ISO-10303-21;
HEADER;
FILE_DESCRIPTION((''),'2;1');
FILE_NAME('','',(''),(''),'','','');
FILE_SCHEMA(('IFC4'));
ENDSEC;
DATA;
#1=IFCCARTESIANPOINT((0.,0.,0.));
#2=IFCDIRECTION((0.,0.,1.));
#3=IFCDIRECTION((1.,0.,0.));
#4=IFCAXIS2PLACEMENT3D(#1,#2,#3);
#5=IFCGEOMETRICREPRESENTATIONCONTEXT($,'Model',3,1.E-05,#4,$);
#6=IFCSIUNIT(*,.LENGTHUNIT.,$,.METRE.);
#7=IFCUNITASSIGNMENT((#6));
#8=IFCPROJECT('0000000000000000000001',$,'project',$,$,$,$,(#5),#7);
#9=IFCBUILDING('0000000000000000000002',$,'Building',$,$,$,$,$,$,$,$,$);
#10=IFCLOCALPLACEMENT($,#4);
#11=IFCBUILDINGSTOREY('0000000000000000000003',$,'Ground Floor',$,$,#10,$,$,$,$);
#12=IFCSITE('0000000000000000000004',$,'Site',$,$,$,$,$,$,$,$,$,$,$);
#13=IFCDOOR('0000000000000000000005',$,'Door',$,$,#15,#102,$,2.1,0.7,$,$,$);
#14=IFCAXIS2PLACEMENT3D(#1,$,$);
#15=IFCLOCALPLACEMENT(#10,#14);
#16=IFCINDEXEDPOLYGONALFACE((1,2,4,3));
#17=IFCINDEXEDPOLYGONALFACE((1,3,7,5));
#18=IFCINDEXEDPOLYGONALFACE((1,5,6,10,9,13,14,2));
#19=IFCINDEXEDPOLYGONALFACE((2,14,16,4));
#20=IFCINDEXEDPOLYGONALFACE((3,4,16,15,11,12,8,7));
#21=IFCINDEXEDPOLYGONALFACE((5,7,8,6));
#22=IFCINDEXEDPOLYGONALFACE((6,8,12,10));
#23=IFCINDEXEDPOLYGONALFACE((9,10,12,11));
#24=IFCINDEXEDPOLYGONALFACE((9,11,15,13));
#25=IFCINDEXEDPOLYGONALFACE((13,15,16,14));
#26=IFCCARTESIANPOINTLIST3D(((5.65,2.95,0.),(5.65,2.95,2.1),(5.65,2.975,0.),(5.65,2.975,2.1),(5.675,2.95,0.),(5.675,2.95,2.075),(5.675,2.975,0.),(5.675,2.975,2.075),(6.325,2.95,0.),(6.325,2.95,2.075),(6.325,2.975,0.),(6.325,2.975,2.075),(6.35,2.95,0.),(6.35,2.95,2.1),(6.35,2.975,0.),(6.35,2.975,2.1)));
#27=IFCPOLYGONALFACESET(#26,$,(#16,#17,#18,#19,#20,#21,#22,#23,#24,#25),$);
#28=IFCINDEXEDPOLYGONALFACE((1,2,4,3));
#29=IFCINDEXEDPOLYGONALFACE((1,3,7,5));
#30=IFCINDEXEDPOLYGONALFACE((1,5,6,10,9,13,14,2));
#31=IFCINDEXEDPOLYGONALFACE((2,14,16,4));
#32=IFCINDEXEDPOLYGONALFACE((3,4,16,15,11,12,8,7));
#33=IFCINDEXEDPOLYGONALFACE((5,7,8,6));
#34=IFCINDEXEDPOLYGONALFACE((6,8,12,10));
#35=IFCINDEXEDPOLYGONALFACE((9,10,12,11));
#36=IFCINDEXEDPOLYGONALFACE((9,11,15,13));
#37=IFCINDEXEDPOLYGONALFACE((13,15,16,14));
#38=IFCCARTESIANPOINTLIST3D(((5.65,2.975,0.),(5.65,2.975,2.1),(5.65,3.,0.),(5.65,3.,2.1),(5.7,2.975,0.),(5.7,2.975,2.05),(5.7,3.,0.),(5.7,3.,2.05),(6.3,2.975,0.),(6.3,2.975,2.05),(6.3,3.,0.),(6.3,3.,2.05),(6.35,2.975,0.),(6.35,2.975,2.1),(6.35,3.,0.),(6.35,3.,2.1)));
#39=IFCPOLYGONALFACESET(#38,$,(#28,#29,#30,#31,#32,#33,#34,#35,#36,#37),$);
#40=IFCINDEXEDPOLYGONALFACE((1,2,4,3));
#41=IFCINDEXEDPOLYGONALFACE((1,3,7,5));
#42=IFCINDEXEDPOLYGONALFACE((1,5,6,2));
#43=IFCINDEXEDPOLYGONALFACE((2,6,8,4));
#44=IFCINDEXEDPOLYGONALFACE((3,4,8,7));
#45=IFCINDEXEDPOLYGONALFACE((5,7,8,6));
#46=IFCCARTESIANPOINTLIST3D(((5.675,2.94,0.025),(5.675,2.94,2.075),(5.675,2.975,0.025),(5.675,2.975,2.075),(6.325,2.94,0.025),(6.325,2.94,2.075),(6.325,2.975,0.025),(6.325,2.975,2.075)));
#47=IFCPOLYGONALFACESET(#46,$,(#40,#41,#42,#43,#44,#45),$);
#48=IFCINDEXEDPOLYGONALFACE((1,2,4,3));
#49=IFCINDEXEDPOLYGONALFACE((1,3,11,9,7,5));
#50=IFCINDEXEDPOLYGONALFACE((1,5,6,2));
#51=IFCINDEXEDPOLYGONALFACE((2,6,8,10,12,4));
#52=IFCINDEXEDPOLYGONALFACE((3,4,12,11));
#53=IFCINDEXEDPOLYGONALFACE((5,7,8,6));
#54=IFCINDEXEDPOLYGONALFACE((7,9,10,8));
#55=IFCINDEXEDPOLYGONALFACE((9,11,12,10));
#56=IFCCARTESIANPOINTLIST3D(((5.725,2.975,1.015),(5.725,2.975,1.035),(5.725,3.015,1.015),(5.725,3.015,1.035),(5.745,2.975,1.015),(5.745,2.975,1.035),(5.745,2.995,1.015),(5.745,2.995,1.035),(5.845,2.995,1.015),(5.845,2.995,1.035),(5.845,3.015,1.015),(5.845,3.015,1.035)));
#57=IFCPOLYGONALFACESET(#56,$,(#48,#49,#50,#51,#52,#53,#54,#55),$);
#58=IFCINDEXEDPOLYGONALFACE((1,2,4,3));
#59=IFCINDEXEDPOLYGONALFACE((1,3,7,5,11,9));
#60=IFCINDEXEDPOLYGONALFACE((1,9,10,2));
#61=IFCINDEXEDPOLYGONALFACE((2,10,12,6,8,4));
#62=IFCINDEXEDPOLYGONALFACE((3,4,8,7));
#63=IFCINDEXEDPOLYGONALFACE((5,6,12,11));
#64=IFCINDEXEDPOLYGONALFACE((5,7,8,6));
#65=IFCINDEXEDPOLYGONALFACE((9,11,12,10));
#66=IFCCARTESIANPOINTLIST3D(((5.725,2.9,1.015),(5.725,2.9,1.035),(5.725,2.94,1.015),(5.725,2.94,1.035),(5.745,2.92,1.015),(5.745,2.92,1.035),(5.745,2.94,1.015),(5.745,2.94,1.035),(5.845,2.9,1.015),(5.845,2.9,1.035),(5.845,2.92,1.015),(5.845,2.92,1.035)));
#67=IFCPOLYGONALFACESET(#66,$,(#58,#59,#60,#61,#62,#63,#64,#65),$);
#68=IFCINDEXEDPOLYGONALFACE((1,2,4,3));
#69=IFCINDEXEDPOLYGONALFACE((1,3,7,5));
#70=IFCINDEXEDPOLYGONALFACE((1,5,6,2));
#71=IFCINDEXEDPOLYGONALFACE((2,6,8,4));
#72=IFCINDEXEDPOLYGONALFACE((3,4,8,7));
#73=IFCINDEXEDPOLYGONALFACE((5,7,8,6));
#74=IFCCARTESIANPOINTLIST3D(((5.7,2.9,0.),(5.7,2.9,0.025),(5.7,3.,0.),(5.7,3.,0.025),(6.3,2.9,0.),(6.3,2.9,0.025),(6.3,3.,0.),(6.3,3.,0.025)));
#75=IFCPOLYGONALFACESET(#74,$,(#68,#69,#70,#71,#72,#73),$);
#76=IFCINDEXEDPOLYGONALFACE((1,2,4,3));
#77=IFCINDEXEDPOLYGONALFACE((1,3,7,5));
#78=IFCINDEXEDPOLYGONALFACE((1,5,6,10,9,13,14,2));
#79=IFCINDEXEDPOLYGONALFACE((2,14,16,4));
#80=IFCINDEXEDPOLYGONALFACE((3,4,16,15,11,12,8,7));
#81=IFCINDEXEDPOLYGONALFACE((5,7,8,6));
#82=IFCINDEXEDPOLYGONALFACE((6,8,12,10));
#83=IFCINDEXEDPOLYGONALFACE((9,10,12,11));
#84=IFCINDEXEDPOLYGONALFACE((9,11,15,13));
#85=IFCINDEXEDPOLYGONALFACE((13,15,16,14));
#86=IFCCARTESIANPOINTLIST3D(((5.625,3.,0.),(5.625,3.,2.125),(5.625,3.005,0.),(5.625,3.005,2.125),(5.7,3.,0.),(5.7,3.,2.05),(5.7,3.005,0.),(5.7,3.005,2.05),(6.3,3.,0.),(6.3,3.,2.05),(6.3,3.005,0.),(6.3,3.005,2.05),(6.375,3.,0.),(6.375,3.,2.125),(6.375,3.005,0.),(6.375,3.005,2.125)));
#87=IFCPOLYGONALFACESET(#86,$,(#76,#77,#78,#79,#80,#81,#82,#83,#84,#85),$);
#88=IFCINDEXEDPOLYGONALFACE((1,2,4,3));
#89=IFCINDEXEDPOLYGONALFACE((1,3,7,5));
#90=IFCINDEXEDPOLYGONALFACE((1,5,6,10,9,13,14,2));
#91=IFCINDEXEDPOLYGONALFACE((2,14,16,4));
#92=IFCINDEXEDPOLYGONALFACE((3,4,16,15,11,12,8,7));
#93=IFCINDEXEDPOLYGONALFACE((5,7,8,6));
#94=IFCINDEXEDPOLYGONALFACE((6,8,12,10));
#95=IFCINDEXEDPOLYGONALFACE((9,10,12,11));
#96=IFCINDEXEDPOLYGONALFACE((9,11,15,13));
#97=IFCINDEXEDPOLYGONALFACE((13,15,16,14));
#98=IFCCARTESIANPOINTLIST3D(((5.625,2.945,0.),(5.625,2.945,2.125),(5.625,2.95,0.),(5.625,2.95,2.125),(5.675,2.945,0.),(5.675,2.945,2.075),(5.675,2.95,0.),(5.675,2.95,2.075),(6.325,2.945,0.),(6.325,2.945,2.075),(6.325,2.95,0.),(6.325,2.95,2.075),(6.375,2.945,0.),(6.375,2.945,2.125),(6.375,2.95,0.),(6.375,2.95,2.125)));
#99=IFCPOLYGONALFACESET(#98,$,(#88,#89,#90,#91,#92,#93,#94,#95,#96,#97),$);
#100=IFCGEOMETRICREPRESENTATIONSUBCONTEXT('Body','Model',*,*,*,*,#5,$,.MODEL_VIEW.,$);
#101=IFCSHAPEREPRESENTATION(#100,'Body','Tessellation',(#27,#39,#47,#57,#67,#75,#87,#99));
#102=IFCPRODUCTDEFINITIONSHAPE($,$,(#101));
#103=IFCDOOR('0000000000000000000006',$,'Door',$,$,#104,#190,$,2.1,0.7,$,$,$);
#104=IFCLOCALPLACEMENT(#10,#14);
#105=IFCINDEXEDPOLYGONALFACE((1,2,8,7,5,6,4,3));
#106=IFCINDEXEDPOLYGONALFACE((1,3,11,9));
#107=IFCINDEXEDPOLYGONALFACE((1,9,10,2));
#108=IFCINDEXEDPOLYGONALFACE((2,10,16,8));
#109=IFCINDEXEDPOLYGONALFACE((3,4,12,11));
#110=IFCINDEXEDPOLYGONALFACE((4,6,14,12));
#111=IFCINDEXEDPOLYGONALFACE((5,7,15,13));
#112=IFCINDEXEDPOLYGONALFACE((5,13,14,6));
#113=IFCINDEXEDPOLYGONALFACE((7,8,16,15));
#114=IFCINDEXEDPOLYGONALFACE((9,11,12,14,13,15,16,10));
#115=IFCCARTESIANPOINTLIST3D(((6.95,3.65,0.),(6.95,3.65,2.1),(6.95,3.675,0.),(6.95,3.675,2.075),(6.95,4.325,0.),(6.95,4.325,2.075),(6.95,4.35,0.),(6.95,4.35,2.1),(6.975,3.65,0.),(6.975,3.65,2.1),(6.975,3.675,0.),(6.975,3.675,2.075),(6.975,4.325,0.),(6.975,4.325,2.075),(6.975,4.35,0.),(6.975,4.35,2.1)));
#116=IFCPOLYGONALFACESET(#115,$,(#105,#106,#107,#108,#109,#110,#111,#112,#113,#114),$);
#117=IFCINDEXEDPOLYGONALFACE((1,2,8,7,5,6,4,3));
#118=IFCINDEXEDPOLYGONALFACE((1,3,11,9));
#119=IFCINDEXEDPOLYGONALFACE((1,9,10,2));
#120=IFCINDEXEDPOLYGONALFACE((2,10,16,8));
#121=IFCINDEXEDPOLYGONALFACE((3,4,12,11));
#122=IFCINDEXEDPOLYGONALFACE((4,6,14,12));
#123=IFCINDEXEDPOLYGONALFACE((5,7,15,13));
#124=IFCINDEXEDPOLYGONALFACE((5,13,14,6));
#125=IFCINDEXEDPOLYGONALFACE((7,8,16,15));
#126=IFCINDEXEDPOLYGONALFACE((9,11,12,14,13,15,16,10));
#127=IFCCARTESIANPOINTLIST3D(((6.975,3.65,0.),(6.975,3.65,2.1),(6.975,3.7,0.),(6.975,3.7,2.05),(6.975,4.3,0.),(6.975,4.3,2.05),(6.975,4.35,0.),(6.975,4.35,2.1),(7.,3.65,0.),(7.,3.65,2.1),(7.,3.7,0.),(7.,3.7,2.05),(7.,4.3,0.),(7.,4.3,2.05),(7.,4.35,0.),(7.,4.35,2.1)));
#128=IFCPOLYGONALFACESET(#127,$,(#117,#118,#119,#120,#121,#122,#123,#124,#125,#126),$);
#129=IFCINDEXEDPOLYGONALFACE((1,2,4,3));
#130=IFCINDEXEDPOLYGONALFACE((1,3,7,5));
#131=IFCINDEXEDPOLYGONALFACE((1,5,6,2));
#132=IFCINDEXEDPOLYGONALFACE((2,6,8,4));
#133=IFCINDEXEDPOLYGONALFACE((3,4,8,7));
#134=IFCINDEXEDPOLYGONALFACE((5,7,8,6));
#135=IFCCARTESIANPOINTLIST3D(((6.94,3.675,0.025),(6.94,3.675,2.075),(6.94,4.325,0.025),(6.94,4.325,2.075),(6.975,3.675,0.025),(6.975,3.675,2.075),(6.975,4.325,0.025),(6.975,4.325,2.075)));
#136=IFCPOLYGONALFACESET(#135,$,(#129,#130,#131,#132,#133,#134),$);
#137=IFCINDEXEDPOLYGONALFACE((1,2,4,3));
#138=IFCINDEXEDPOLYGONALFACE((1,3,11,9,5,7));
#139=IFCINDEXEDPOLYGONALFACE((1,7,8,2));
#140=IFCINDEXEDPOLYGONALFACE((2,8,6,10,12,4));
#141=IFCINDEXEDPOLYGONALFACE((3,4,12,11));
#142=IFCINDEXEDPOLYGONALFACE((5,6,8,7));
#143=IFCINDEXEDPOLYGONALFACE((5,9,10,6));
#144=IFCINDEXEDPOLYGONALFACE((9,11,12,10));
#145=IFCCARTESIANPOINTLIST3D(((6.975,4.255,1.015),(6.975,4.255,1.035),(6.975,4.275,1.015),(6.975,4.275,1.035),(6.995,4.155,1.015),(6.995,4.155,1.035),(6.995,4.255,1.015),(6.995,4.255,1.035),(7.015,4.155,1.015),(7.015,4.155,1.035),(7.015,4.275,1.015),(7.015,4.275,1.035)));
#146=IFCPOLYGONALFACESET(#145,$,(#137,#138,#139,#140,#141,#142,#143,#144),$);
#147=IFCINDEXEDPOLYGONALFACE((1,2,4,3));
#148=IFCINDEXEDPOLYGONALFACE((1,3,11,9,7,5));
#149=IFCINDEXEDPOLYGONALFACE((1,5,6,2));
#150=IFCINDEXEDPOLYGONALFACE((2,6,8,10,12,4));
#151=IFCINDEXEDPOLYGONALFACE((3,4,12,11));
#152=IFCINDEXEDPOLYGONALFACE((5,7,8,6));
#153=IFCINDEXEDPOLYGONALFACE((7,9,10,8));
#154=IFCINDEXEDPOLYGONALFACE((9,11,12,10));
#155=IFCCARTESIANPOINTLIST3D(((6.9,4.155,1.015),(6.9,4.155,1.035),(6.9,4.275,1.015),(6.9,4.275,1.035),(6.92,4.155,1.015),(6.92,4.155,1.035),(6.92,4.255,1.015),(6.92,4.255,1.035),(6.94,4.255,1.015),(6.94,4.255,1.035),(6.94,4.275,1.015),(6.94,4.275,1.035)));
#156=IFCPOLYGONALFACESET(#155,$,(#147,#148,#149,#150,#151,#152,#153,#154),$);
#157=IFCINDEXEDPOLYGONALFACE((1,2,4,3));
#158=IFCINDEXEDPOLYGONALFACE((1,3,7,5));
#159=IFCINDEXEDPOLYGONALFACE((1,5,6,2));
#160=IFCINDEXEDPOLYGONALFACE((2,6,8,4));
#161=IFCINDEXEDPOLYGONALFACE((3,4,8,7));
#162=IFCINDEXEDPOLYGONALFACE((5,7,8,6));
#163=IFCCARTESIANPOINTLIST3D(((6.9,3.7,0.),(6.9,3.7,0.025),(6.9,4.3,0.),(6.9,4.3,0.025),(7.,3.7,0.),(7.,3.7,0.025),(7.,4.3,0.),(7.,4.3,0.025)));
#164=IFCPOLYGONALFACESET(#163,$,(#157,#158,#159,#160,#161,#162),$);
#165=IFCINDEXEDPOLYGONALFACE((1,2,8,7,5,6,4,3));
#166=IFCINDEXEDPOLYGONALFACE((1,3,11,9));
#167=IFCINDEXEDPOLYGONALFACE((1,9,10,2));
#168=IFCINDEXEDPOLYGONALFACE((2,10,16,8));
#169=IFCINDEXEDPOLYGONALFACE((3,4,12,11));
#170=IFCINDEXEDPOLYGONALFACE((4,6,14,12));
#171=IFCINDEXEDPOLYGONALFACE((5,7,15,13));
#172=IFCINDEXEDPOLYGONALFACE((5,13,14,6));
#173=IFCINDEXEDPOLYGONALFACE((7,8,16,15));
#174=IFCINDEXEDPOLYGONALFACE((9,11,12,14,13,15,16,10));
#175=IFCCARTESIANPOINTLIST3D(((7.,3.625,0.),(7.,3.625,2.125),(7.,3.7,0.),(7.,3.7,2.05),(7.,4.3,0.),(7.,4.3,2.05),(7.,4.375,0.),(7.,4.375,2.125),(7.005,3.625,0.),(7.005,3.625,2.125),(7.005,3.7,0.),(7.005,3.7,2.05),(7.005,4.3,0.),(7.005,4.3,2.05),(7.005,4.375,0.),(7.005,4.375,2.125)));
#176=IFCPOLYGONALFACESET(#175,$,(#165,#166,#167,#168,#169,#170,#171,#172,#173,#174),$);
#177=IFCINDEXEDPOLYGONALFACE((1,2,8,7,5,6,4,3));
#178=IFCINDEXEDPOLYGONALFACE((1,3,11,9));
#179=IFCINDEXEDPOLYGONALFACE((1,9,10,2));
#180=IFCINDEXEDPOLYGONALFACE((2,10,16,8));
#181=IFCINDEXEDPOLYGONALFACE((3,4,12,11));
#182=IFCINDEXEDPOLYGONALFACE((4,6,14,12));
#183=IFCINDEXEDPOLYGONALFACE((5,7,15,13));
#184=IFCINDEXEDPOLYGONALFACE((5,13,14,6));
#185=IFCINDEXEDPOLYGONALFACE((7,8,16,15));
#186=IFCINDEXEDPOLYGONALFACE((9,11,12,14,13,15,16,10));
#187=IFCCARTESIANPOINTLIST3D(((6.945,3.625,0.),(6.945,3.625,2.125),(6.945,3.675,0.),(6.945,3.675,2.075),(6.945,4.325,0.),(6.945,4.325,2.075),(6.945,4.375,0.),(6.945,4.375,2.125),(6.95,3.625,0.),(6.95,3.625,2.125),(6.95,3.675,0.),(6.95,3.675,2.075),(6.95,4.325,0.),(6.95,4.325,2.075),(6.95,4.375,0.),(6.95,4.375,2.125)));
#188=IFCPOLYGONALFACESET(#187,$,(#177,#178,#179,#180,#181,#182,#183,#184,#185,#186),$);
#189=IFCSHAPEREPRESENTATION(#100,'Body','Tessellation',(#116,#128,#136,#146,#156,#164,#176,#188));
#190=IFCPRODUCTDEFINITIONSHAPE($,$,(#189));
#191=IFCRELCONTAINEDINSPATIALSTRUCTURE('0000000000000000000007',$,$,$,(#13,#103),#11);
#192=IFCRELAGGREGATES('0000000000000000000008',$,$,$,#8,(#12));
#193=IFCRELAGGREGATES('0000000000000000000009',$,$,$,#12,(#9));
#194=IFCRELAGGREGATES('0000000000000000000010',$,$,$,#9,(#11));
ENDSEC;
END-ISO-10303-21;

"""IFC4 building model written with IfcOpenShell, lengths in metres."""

from ifc_helpers import new_model, si_unit, frame, origin_with_axes, place, context, subcontext, project, spatial, line, indexed_curve, outline, extrude, element, save


model = new_model("IFC4")

# Units and contexts
model_context = context("Model", 3, precision=1e-05, world=origin_with_axes())
body_context = subcontext(model_context, "Body", "Model", "MODEL_VIEW")
ifc_project = project(units=[si_unit("LENGTHUNIT", "METRE")], contexts=[model_context])

# Site, building, storey
site = spatial("IfcSite", under=ifc_project, Name="Site")
building = spatial("IfcBuilding", under=site, Name="Building")
storey_placement = place(None, origin_with_axes())
storey = spatial("IfcBuildingStorey", under=building, at=storey_placement, Name="Ground Floor")

# Doors
door_1_placement = place(storey_placement, frame((6.35, 3.0, 0.0), z_axis=(0.0, 0.0, 1.0), x_axis=(-1.0, 0.0, 0.0)))
element("IfcDoor", 1, at=door_1_placement, inside=storey, Name="Door", OverallHeight=2.1, OverallWidth=0.7, context=body_context, shape_type="SweptSolid", body=[
    extrude(outline(indexed_curve([(0.0, 0.0), (0.0, 2.1), (0.7, 2.1), (0.7, 0.0), (0.675, 0.0), (0.675, 2.075), (0.025, 2.075), (0.025, 0.0)], segments=[line(1, 2, 3, 4, 5, 6, 7, 8, 1)])), frame((0.0, 0.025, 0.0), z_axis=(0.0, -1.0, 0.0), x_axis=(1.0, 0.0, 0.0)), (0.0, 0.0, -1.0), 0.025),
    extrude(outline(indexed_curve([(0.0, 0.0), (0.0, 2.1), (0.7, 2.1), (0.7, 0.0), (0.65, 0.0), (0.65, 2.05), (0.05, 2.05), (0.05, 0.0)], segments=[line(1, 2, 3, 4, 5, 6, 7, 8, 1)])), frame((0.0, 0.0, 0.0), z_axis=(0.0, -1.0, 0.0), x_axis=(1.0, 0.0, 0.0)), (0.0, 0.0, -1.0), 0.025),
    extrude(outline(indexed_curve([(0.0, 0.0), (0.65, 0.0), (0.65, 0.035), (0.0, 0.035)], segments=[line(1, 2, 3, 4, 1)])), frame((0.025, 0.025, 0.025), z_axis=(0.0, 0.0, 1.0), x_axis=(1.0, 0.0, 0.0)), (0.0, 0.0, 1.0), 2.05),
    extrude(outline(indexed_curve([(0.0, 0.0), (0.0, -0.04), (-0.12, -0.04), (-0.12, -0.02), (-0.02, -0.02), (-0.02, 0.0)], segments=[line(1, 2, 3, 4, 5, 6, 1)])), frame((0.625, 0.025, 1.015), z_axis=(0.0, 0.0, 1.0), x_axis=(1.0, 0.0, 0.0)), (0.0, 0.0, 1.0), 0.02),
    extrude(outline(indexed_curve([(0.0, 0.0), (0.0, 0.04), (-0.12, 0.04), (-0.12, 0.02), (-0.02, 0.02), (-0.02, 0.0)], segments=[line(1, 2, 3, 4, 5, 6, 1)])), frame((0.625, 0.06, 1.015), z_axis=(0.0, 0.0, 1.0), x_axis=(1.0, 0.0, 0.0)), (0.0, 0.0, 1.0), 0.02),
    extrude(outline(indexed_curve([(0.0, 0.0), (0.6, 0.0), (0.6, 0.1), (0.0, 0.1)], segments=[line(1, 2, 3, 4, 1)])), frame((0.05, 0.0, 0.0), z_axis=(0.0, 0.0, 1.0), x_axis=(1.0, 0.0, 0.0)), (0.0, 0.0, 1.0), 0.025),
    extrude(outline(indexed_curve([(0.0, 0.0), (0.0, 2.125), (0.75, 2.125), (0.75, 0.0), (0.675, 0.0), (0.675, 2.05), (0.075, 2.05), (0.075, 0.0)], segments=[line(1, 2, 3, 4, 5, 6, 7, 8, 1)])), frame((-0.025, -0.005, 0.0), z_axis=(0.0, -1.0, 0.0), x_axis=(1.0, 0.0, 0.0)), (0.0, 0.0, -1.0), 0.005),
    extrude(outline(indexed_curve([(0.0, 0.0), (0.0, 2.125), (0.75, 2.125), (0.75, 0.0), (0.7, 0.0), (0.7, 2.075), (0.05, 2.075), (0.05, 0.0)], segments=[line(1, 2, 3, 4, 5, 6, 7, 8, 1)])), frame((-0.025, 0.05, 0.0), z_axis=(0.0, -1.0, 0.0), x_axis=(1.0, 0.0, 0.0)), (0.0, 0.0, -1.0), 0.005),
])
door_2_placement = place(storey_placement, frame((7.0, 3.65, 0.0), z_axis=(0.0, 0.0, 1.0), x_axis=(0.0, 1.0, 0.0)))
element("IfcDoor", 2, at=door_2_placement, inside=storey, Name="Door", OverallHeight=2.1, OverallWidth=0.7, context=body_context, shape_type="SweptSolid", body=[
    extrude(outline(indexed_curve([(0.0, 0.0), (0.0, 2.1), (0.7, 2.1), (0.7, 0.0), (0.675, 0.0), (0.675, 2.075), (0.025, 2.075), (0.025, 0.0)], segments=[line(1, 2, 3, 4, 5, 6, 7, 8, 1)])), frame((0.0, 0.025, 0.0), z_axis=(0.0, -1.0, 0.0), x_axis=(1.0, 0.0, 0.0)), (0.0, 0.0, -1.0), 0.025),
    extrude(outline(indexed_curve([(0.0, 0.0), (0.0, 2.1), (0.7, 2.1), (0.7, 0.0), (0.65, 0.0), (0.65, 2.05), (0.05, 2.05), (0.05, 0.0)], segments=[line(1, 2, 3, 4, 5, 6, 7, 8, 1)])), frame((0.0, 0.0, 0.0), z_axis=(0.0, -1.0, 0.0), x_axis=(1.0, 0.0, 0.0)), (0.0, 0.0, -1.0), 0.025),
    extrude(outline(indexed_curve([(0.0, 0.0), (0.65, 0.0), (0.65, 0.035), (0.0, 0.035)], segments=[line(1, 2, 3, 4, 1)])), frame((0.025, 0.025, 0.025), z_axis=(0.0, 0.0, 1.0), x_axis=(1.0, 0.0, 0.0)), (0.0, 0.0, 1.0), 2.05),
    extrude(outline(indexed_curve([(0.0, 0.0), (0.0, -0.04), (-0.12, -0.04), (-0.12, -0.02), (-0.02, -0.02), (-0.02, 0.0)], segments=[line(1, 2, 3, 4, 5, 6, 1)])), frame((0.625, 0.025, 1.015), z_axis=(0.0, 0.0, 1.0), x_axis=(1.0, 0.0, 0.0)), (0.0, 0.0, 1.0), 0.02),
    extrude(outline(indexed_curve([(0.0, 0.0), (0.0, 0.04), (-0.12, 0.04), (-0.12, 0.02), (-0.02, 0.02), (-0.02, 0.0)], segments=[line(1, 2, 3, 4, 5, 6, 1)])), frame((0.625, 0.06, 1.015), z_axis=(0.0, 0.0, 1.0), x_axis=(1.0, 0.0, 0.0)), (0.0, 0.0, 1.0), 0.02),
    extrude(outline(indexed_curve([(0.0, 0.0), (0.6, 0.0), (0.6, 0.1), (0.0, 0.1)], segments=[line(1, 2, 3, 4, 1)])), frame((0.05, 0.0, 0.0), z_axis=(0.0, 0.0, 1.0), x_axis=(1.0, 0.0, 0.0)), (0.0, 0.0, 1.0), 0.025),
    extrude(outline(indexed_curve([(0.0, 0.0), (0.0, 2.125), (0.75, 2.125), (0.75, 0.0), (0.675, 0.0), (0.675, 2.05), (0.075, 2.05), (0.075, 0.0)], segments=[line(1, 2, 3, 4, 5, 6, 7, 8, 1)])), frame((-0.025, -0.005, 0.0), z_axis=(0.0, -1.0, 0.0), x_axis=(1.0, 0.0, 0.0)), (0.0, 0.0, -1.0), 0.005),
    extrude(outline(indexed_curve([(0.0, 0.0), (0.0, 2.125), (0.75, 2.125), (0.75, 0.0), (0.7, 0.0), (0.7, 2.075), (0.05, 2.075), (0.05, 0.0)], segments=[line(1, 2, 3, 4, 5, 6, 7, 8, 1)])), frame((-0.025, 0.05, 0.0), z_axis=(0.0, -1.0, 0.0), x_axis=(1.0, 0.0, 0.0)), (0.0, 0.0, -1.0), 0.005),
])

save(model, "model.ifc")
